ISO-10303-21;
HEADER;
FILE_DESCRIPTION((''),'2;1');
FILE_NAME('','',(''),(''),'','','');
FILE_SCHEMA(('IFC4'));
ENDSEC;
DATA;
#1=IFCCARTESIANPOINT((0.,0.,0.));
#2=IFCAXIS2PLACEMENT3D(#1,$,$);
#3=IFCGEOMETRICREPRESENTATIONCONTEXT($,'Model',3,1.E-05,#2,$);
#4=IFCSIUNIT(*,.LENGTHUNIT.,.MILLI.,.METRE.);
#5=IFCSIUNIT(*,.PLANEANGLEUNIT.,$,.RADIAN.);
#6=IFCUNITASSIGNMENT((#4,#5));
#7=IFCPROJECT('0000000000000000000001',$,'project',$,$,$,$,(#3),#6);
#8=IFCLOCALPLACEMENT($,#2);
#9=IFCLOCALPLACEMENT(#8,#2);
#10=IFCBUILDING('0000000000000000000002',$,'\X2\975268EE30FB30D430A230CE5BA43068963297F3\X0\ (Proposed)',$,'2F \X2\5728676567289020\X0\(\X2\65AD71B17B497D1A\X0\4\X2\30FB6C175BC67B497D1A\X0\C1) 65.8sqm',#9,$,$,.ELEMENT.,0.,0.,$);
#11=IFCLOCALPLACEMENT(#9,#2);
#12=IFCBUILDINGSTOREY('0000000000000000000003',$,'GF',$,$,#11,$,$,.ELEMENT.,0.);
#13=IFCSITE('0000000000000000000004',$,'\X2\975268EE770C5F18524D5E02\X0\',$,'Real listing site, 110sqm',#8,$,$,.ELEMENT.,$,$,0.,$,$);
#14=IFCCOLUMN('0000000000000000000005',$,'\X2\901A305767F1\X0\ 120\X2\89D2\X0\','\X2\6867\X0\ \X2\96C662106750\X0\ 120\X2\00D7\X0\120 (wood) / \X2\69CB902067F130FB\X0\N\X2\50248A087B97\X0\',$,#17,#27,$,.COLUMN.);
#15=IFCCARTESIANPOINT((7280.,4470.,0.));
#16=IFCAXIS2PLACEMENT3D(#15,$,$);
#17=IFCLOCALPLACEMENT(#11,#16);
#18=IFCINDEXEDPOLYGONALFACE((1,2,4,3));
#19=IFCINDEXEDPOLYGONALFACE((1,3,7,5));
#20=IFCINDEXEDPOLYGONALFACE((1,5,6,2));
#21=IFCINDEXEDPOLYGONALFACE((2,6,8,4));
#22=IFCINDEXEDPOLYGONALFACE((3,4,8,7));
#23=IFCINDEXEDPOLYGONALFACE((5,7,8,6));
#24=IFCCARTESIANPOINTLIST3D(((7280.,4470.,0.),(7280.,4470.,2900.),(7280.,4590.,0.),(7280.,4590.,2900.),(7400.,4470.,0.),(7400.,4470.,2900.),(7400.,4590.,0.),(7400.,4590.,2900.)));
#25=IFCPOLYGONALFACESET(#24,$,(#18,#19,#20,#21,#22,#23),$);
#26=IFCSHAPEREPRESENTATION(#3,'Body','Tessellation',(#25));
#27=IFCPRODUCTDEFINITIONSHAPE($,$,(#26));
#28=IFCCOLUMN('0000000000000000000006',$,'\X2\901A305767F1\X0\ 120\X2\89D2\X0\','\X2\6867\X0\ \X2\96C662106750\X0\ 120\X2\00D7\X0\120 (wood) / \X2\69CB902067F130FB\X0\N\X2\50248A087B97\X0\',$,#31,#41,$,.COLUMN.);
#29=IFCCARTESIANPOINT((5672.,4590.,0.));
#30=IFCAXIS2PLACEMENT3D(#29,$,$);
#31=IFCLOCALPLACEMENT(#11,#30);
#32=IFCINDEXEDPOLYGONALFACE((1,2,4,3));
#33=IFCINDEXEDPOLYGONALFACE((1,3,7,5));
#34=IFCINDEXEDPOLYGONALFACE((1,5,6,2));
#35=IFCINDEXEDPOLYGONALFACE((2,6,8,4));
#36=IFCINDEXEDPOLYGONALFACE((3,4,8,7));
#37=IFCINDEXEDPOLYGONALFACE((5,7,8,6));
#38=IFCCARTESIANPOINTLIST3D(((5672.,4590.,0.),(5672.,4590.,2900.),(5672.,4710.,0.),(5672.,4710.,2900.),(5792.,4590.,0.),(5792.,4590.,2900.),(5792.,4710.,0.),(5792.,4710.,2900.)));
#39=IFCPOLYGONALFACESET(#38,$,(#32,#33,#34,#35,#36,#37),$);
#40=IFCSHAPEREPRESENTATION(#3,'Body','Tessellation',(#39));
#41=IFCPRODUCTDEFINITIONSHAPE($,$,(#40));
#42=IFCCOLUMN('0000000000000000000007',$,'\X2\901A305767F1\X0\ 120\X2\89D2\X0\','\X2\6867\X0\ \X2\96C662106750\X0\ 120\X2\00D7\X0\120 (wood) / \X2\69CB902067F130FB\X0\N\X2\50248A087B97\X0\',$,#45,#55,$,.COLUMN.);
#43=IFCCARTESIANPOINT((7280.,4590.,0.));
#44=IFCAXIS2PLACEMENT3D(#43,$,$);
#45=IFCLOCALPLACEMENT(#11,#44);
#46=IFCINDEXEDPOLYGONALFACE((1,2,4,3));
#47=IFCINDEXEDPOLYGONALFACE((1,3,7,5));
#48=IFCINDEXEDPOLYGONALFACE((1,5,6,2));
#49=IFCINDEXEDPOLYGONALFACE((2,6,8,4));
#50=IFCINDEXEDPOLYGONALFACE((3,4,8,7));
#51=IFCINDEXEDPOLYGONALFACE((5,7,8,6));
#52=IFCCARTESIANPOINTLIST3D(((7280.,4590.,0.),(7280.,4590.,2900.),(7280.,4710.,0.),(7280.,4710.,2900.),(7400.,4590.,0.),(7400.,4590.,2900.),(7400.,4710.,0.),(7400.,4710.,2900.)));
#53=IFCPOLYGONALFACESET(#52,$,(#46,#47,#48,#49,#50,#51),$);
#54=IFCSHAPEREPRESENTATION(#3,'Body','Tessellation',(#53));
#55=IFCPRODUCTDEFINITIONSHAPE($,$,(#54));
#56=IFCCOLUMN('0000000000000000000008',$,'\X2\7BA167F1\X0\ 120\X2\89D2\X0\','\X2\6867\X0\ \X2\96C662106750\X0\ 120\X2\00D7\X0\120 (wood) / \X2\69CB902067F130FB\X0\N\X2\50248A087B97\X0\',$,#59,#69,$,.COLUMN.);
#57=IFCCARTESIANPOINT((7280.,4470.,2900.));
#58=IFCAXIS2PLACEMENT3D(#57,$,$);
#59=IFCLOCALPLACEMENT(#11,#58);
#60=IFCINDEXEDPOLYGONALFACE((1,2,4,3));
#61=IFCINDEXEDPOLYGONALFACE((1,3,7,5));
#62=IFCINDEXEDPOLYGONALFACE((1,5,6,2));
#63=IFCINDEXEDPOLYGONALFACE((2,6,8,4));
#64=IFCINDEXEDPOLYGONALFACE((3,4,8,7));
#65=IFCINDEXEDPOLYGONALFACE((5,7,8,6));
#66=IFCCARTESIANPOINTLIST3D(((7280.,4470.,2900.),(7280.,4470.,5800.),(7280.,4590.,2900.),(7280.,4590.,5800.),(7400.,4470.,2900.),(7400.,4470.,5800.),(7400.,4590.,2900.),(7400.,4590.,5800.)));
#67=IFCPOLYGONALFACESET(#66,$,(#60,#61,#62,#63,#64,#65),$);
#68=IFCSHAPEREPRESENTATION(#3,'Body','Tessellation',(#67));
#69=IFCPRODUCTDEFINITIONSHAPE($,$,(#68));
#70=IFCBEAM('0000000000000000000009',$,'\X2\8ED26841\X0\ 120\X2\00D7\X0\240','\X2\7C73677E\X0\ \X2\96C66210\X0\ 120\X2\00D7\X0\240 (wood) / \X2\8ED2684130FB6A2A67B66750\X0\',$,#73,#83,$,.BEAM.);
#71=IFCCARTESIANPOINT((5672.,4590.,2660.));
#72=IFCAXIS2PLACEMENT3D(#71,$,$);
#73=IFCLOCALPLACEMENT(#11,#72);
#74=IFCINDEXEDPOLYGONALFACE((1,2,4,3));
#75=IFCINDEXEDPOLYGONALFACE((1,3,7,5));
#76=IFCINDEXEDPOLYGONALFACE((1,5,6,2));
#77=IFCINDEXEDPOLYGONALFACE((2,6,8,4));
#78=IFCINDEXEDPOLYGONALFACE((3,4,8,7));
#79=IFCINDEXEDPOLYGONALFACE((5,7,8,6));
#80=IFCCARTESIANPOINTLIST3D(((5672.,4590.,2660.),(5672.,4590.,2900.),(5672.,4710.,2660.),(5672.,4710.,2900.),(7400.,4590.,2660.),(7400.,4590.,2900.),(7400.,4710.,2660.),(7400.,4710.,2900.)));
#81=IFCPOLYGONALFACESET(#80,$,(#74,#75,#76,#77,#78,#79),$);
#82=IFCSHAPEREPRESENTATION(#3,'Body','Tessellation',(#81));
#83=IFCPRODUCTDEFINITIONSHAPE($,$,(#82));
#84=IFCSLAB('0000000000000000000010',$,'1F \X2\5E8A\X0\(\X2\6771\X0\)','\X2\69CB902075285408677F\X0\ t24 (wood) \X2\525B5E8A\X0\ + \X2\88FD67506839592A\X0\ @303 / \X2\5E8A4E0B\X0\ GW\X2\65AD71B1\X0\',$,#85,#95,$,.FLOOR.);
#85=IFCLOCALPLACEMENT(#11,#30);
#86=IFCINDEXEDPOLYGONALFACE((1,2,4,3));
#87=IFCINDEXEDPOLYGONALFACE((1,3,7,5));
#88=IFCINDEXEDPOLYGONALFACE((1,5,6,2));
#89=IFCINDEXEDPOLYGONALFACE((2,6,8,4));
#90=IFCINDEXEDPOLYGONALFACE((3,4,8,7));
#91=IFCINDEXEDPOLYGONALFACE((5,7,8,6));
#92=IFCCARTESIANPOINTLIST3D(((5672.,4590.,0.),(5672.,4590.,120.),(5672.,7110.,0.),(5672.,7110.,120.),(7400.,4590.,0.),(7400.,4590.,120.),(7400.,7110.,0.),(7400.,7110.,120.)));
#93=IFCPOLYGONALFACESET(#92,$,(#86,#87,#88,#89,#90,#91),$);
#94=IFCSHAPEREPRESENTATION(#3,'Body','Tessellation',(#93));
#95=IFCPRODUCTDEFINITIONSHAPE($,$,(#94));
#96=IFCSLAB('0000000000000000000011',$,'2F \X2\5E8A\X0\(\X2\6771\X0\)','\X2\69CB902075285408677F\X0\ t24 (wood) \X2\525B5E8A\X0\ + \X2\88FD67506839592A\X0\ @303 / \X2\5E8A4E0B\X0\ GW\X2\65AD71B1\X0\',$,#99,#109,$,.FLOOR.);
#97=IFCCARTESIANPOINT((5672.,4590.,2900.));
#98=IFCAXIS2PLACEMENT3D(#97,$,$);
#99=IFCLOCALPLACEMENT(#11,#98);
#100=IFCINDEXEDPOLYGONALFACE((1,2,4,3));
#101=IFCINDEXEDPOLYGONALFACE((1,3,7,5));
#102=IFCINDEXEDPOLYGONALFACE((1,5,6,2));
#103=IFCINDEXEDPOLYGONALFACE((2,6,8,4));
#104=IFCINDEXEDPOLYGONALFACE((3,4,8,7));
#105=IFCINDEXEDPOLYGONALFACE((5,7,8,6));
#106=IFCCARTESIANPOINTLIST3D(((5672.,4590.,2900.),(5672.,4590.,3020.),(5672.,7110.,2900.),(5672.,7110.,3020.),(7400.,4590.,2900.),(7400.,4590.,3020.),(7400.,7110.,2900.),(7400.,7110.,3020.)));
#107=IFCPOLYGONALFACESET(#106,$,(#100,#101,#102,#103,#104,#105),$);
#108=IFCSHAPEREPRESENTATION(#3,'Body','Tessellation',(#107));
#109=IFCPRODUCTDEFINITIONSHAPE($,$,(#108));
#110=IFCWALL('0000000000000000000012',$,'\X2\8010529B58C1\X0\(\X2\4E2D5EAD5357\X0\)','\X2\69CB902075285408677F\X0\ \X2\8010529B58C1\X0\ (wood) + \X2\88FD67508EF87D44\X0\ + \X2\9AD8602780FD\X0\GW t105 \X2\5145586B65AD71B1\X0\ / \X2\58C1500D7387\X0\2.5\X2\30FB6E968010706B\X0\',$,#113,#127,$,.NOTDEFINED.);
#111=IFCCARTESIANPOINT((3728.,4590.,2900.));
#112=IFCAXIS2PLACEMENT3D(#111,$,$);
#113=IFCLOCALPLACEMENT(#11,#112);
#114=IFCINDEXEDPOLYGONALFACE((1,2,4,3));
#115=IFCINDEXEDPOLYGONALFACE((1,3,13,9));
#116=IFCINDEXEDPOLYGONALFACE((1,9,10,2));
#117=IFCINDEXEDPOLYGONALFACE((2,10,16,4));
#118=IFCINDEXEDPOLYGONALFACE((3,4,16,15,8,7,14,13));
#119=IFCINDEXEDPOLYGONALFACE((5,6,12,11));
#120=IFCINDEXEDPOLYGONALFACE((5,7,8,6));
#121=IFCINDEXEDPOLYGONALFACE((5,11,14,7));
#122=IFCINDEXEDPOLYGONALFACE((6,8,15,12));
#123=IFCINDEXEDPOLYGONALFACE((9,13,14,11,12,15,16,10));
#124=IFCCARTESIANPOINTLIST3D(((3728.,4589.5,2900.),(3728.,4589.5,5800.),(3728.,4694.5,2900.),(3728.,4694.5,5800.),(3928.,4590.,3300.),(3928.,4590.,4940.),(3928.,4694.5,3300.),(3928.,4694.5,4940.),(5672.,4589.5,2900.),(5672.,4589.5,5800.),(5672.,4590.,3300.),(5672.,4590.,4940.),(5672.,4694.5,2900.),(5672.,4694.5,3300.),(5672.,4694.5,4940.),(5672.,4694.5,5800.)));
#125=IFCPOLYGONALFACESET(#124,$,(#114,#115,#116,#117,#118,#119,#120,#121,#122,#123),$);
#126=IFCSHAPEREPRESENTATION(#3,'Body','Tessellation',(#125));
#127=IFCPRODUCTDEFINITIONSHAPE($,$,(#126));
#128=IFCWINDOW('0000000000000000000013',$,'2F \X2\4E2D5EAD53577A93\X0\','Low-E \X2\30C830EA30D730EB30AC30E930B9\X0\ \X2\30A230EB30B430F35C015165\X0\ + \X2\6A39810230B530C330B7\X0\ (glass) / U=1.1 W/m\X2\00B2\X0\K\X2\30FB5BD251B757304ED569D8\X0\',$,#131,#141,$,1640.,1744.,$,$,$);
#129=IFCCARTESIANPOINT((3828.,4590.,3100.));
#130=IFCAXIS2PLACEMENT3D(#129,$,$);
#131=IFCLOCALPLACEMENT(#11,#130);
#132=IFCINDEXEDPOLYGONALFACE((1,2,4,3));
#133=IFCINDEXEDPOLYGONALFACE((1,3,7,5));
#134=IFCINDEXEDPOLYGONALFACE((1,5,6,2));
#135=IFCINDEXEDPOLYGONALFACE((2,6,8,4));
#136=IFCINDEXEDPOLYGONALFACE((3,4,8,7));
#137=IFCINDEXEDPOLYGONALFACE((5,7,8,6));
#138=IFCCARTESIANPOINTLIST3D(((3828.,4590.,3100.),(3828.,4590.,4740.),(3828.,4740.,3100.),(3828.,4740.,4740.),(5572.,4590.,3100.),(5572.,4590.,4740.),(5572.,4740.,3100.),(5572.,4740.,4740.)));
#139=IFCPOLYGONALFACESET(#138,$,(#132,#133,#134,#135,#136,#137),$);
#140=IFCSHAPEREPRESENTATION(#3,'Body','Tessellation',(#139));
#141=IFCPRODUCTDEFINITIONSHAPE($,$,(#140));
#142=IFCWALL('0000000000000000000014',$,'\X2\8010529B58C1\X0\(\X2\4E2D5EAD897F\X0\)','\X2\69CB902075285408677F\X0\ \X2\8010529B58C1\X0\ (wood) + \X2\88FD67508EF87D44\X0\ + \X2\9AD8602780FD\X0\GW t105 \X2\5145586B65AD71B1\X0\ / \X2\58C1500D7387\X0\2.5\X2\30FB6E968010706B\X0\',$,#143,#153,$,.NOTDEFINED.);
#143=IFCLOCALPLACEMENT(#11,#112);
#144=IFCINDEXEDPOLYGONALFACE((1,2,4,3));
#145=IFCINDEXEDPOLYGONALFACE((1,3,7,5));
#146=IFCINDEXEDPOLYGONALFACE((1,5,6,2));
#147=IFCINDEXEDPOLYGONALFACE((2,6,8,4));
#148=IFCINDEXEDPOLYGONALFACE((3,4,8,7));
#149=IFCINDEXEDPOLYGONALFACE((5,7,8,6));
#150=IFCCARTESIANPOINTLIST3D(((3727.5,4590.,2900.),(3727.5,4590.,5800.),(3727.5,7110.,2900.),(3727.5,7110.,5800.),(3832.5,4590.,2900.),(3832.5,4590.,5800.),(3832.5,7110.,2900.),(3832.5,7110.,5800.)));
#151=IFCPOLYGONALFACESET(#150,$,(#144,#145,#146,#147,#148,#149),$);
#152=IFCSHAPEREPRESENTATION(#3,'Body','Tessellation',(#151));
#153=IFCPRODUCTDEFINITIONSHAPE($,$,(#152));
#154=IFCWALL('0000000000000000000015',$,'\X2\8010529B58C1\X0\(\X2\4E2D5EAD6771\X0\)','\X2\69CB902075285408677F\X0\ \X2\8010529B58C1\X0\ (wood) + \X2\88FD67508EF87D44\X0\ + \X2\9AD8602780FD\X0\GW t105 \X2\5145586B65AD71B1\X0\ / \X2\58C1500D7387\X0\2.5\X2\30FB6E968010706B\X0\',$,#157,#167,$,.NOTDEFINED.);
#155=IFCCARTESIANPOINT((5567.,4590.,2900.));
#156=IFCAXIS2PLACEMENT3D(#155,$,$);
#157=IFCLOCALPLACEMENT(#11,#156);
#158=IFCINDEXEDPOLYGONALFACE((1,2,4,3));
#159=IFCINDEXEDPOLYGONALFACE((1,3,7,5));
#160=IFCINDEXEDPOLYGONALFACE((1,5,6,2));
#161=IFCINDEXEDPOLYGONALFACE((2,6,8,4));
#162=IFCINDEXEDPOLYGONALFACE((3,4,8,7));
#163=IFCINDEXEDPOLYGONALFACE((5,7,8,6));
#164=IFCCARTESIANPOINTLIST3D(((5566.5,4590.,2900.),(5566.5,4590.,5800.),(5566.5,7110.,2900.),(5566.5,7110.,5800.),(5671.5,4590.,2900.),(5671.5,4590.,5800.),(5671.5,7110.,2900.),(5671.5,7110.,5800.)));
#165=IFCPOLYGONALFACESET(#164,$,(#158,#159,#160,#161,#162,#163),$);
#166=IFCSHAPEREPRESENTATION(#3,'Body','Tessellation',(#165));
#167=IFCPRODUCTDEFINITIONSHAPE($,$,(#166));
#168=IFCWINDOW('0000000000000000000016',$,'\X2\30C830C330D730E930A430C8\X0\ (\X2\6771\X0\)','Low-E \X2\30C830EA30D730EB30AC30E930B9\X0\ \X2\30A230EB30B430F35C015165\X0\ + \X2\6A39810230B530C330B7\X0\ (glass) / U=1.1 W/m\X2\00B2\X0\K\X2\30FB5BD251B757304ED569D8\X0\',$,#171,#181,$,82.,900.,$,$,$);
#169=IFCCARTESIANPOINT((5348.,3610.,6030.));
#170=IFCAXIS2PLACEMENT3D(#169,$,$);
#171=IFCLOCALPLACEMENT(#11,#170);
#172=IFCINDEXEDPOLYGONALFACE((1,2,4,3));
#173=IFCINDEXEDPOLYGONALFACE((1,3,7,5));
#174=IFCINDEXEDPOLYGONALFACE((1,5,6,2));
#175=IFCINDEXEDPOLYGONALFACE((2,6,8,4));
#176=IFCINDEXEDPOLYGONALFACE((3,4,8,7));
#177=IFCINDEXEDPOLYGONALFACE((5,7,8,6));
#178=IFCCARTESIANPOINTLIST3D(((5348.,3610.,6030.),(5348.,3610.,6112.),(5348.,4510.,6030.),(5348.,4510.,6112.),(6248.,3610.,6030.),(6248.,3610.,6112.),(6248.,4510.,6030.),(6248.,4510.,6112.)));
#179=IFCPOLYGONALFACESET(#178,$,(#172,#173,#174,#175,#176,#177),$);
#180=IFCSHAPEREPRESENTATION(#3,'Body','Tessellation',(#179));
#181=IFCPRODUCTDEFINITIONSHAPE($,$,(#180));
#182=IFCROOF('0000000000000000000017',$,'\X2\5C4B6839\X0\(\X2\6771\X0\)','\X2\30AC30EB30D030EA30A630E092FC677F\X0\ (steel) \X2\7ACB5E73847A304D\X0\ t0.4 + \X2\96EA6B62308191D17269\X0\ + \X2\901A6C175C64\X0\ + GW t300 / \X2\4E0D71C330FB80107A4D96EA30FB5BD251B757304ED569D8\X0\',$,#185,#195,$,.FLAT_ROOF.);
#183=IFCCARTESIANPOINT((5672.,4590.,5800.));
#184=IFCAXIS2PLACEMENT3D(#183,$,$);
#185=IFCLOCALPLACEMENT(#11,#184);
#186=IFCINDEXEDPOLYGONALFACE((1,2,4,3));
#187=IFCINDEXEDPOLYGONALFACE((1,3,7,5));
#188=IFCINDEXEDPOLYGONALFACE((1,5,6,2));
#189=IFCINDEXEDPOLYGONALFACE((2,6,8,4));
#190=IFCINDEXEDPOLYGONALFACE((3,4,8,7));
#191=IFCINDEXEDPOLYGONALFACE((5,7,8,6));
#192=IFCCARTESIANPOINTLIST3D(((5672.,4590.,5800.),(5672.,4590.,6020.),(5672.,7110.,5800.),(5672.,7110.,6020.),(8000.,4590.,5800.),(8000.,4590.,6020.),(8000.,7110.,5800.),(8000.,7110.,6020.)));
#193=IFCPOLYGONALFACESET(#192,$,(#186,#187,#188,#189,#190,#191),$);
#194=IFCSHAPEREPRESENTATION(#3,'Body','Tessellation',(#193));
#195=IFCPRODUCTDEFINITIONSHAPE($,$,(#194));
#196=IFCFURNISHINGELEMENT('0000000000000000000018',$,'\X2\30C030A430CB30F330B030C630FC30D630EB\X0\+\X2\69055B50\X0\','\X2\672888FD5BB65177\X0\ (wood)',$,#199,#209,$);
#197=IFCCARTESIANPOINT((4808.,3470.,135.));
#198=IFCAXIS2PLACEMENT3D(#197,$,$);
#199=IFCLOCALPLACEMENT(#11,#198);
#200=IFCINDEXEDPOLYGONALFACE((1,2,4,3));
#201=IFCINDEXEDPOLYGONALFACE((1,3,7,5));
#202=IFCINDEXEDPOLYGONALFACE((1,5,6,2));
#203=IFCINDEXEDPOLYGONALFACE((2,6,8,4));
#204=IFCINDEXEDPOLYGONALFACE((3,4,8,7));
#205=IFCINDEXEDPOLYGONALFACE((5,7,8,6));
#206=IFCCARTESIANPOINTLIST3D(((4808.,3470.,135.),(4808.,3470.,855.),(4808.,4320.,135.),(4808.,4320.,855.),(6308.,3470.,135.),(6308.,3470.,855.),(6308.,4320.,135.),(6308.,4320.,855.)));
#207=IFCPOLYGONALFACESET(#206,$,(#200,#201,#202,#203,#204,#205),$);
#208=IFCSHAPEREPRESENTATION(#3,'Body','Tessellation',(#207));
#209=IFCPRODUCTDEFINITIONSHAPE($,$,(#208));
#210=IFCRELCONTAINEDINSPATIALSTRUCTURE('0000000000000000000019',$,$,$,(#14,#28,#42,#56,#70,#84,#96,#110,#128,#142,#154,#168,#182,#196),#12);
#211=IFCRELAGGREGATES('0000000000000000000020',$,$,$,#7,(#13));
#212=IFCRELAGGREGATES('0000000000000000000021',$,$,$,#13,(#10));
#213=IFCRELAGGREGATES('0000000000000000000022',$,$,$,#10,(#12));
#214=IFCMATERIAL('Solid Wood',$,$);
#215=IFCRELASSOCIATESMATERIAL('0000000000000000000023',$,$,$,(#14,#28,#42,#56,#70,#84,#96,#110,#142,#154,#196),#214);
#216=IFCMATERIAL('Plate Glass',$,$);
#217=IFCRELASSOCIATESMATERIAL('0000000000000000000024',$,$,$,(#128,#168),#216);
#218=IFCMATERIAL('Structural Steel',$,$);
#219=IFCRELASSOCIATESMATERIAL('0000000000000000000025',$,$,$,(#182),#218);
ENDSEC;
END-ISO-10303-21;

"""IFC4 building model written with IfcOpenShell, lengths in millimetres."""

from ifc_helpers import new_model, si_unit, frame, frame_2d, origin, place, context, project, spatial, rectangle, extrude, material, element, fill, save


model = new_model("IFC4")

# Units and contexts
model_context = context("Model", 3, precision=1e-05, world=origin())
ifc_project = project(units=[si_unit("LENGTHUNIT", "METRE", prefix="MILLI"), si_unit("PLANEANGLEUNIT", "RADIAN")], contexts=[model_context])

# Site, building, storey
site_placement = place(None, origin())
site = spatial("IfcSite", under=ifc_project, at=site_placement, Name="青森県弘前市", ObjectType="Real listing site, 110sqm", CompositionType="ELEMENT", RefElevation=0.0)
building_placement = place(site_placement, origin())
building = spatial("IfcBuilding", under=site, at=building_placement, Name="青森・ピアノ室と防音 (Proposed)", ObjectType="2F 在来木造(断熱等級4・気密等級C1) 65.8sqm", CompositionType="ELEMENT", ElevationOfRefHeight=0.0, ElevationOfTerrain=0.0)
storey_placement = place(building_placement, origin())
storey = spatial("IfcBuildingStorey", under=building, at=storey_placement, Name="GF", CompositionType="ELEMENT", Elevation=0.0)

# Columns
ifc_material_1 = material(Name="Solid Wood")
column_1_placement = place(storey_placement, frame((7280.0, 4470.0, 0.0)))
element("IfcColumn", 1, at=column_1_placement, inside=storey, material=ifc_material_1, Name="通し柱 120角", Description="桧 集成材 120×120 (wood) / 構造柱・N値計算", PredefinedType="COLUMN", context=model_context, shape_type="SweptSolid", body=[
    extrude(rectangle(XDim=120.0, YDim=120.0, at=frame_2d((60.0, 60.0))), frame((7280.0, 4470.0, 0.0)), (0.0, 0.0, 1.0), 2900.0),
])
column_2_placement = place(storey_placement, frame((5672.0, 4590.0, 0.0)))
element("IfcColumn", 2, at=column_2_placement, inside=storey, material=ifc_material_1, Name="通し柱 120角", Description="桧 集成材 120×120 (wood) / 構造柱・N値計算", PredefinedType="COLUMN", context=model_context, shape_type="SweptSolid", body=[
    extrude(rectangle(XDim=120.0, YDim=120.0, at=frame_2d((60.0, 60.0))), frame((5672.0, 4590.0, 0.0)), (0.0, 0.0, 1.0), 2900.0),
])
column_3_placement = place(storey_placement, frame((7280.0, 4590.0, 0.0)))
element("IfcColumn", 3, at=column_3_placement, inside=storey, material=ifc_material_1, Name="通し柱 120角", Description="桧 集成材 120×120 (wood) / 構造柱・N値計算", PredefinedType="COLUMN", context=model_context, shape_type="SweptSolid", body=[
    extrude(rectangle(XDim=120.0, YDim=120.0, at=frame_2d((60.0, 60.0))), frame((7280.0, 4590.0, 0.0)), (0.0, 0.0, 1.0), 2900.0),
])
column_4_placement = place(storey_placement, frame((7280.0, 4470.0, 2900.0)))
element("IfcColumn", 4, at=column_4_placement, inside=storey, material=ifc_material_1, Name="管柱 120角", Description="桧 集成材 120×120 (wood) / 構造柱・N値計算", PredefinedType="COLUMN", context=model_context, shape_type="SweptSolid", body=[
    extrude(rectangle(XDim=120.0, YDim=120.0, at=frame_2d((60.0, 60.0))), frame((7280.0, 4470.0, 2900.0)), (0.0, 0.0, 1.0), 2900.0),
])

# Beam
beam_1_placement = place(storey_placement, frame((5672.0, 4590.0, 2660.0)))
element("IfcBeam", 5, at=beam_1_placement, inside=storey, material=ifc_material_1, Name="軒桁 120×240", Description="米松 集成 120×240 (wood) / 軒桁・横架材", PredefinedType="BEAM", context=model_context, shape_type="SweptSolid", body=[
    extrude(rectangle(XDim=1728.0, YDim=120.0, at=frame_2d((864.0, 60.0))), frame((5672.0, 4590.0, 2660.0)), (0.0, 0.0, 1.0), 240.0),
])

# Slabs
slab_1_placement = place(storey_placement, frame((5672.0, 4590.0, 0.0)))
element("IfcSlab", 6, at=slab_1_placement, inside=storey, material=ifc_material_1, Name="1F 床(東)", Description="構造用合板 t24 (wood) 剛床 + 製材根太 @303 / 床下 GW断熱", PredefinedType="FLOOR", context=model_context, shape_type="SweptSolid", body=[
    extrude(rectangle(XDim=1728.0, YDim=2520.0, at=frame_2d((864.0, 1260.0))), frame((5672.0, 4590.0, 0.0)), (0.0, 0.0, 1.0), 120.0),
])
slab_2_placement = place(storey_placement, frame((5672.0, 4590.0, 2900.0)))
element("IfcSlab", 7, at=slab_2_placement, inside=storey, material=ifc_material_1, Name="2F 床(東)", Description="構造用合板 t24 (wood) 剛床 + 製材根太 @303 / 床下 GW断熱", PredefinedType="FLOOR", context=model_context, shape_type="SweptSolid", body=[
    extrude(rectangle(XDim=1728.0, YDim=2520.0, at=frame_2d((864.0, 1260.0))), frame((5672.0, 4590.0, 2900.0)), (0.0, 0.0, 1.0), 120.0),
])

# Wall, opening, window
wall_1_placement = place(storey_placement, frame((3728.0, 4590.0, 2900.0)))
wall_1 = element("IfcWall", 8, at=wall_1_placement, inside=storey, material=ifc_material_1, Name="耐力壁(中庭南)", Description="構造用合板 耐力壁 (wood) + 製材軸組 + 高性能GW t105 充填断熱 / 壁倍率2.5・準耐火", PredefinedType="NOTDEFINED", context=model_context, shape_type="SweptSolid", body=[
    extrude(rectangle(XDim=1944.0, YDim=105.0, at=frame_2d((972.0, 52.0))), frame((3728.0, 4590.0, 2900.0)), (0.0, 0.0, 1.0), 2900.0),
])
opening_placement = place(storey_placement, frame((3828.0, 4590.0, 3100.0)))
opening = element("IfcOpeningElement", 9, at=opening_placement, cuts=wall_1, PredefinedType="NOTDEFINED", context=model_context, shape_type="SweptSolid", body=[
    extrude(rectangle(XDim=1744.0, YDim=150.0, at=frame_2d((872.0, 75.0))), frame((3828.0, 4590.0, 3100.0)), (0.0, 0.0, 1.0), 1640.0),
])
ifc_material_2 = material(Name="Plate Glass")
window_1_placement = place(storey_placement, frame((3828.0, 4590.0, 3100.0)))
window_1 = element("IfcWindow", 10, at=window_1_placement, inside=storey, material=ifc_material_2, Name="2F 中庭南窓", Description="Low-E トリプルガラス アルゴン封入 + 樹脂サッシ (glass) / U=1.1 W/m²K・寒冷地仕様", OverallHeight=1640.0, OverallWidth=1744.0, context=model_context, shape_type="SweptSolid", body=[
    extrude(rectangle(XDim=1744.0, YDim=150.0, at=frame_2d((872.0, 75.0))), frame((3828.0, 4590.0, 3100.0)), (0.0, 0.0, 1.0), 1640.0),
])
fill(opening, window_1)

# Walls
wall_2_placement = place(storey_placement, frame((3728.0, 4590.0, 2900.0)))
element("IfcWall", 11, at=wall_2_placement, inside=storey, material=ifc_material_1, Name="耐力壁(中庭西)", Description="構造用合板 耐力壁 (wood) + 製材軸組 + 高性能GW t105 充填断熱 / 壁倍率2.5・準耐火", PredefinedType="NOTDEFINED", context=model_context, shape_type="SweptSolid", body=[
    extrude(rectangle(XDim=105.0, YDim=2520.0, at=frame_2d((52.0, 1260.0))), frame((3728.0, 4590.0, 2900.0)), (0.0, 0.0, 1.0), 2900.0),
])
wall_3_placement = place(storey_placement, frame((5567.0, 4590.0, 2900.0)))
element("IfcWall", 12, at=wall_3_placement, inside=storey, material=ifc_material_1, Name="耐力壁(中庭東)", Description="構造用合板 耐力壁 (wood) + 製材軸組 + 高性能GW t105 充填断熱 / 壁倍率2.5・準耐火", PredefinedType="NOTDEFINED", context=model_context, shape_type="SweptSolid", body=[
    extrude(rectangle(XDim=105.0, YDim=2520.0, at=frame_2d((52.0, 1260.0))), frame((5567.0, 4590.0, 2900.0)), (0.0, 0.0, 1.0), 2900.0),
])

# Window
window_2_placement = place(storey_placement, frame((5348.0, 3610.0, 6030.0)))
element("IfcWindow", 13, at=window_2_placement, inside=storey, material=ifc_material_2, Name="トップライト (東)", Description="Low-E トリプルガラス アルゴン封入 + 樹脂サッシ (glass) / U=1.1 W/m²K・寒冷地仕様", OverallHeight=82.0, OverallWidth=900.0, context=model_context, shape_type="SweptSolid", body=[
    extrude(rectangle(XDim=900.0, YDim=900.0, at=frame_2d((450.0, 450.0))), frame((5348.0, 3610.0, 6030.0)), (0.0, 0.0, 1.0), 82.0),
])

# Roof
ifc_material_3 = material(Name="Structural Steel")
for number, where, name in (
    (14, (5672.0, 4590.0, 5800.0), "屋根(東)"),
):
    element("IfcRoof", number, at=place(storey_placement, frame(where)), inside=storey, material=ifc_material_3, Name=name, Description="ガルバリウム鋼板 (steel) 立平葺き t0.4 + 雪止め金物 + 通気層 + GW t300 / 不燃・耐積雪・寒冷地仕様", PredefinedType="FLAT_ROOF", context=model_context, shape_type="SweptSolid", body=[
        extrude(rectangle(XDim=2328.0, YDim=2520.0, at=frame_2d((1164.0, 1260.0))), frame((5672.0, 4590.0, 5800.0)), (0.0, 0.0, 1.0), 220.0),
    ])

# Furnishing element
furnishing_1_placement = place(storey_placement, frame((4808.0, 3470.0, 135.0)))
element("IfcFurnishingElement", 15, at=furnishing_1_placement, inside=storey, material=ifc_material_1, Name="ダイニングテーブル+椅子", Description="木製家具 (wood)", context=model_context, shape_type="SweptSolid", body=[
    extrude(rectangle(XDim=1500.0, YDim=850.0, at=frame_2d((750.0, 425.0))), frame((4808.0, 3470.0, 135.0)), (0.0, 0.0, 1.0), 720.0),
])

save(model, "model.ifc")
